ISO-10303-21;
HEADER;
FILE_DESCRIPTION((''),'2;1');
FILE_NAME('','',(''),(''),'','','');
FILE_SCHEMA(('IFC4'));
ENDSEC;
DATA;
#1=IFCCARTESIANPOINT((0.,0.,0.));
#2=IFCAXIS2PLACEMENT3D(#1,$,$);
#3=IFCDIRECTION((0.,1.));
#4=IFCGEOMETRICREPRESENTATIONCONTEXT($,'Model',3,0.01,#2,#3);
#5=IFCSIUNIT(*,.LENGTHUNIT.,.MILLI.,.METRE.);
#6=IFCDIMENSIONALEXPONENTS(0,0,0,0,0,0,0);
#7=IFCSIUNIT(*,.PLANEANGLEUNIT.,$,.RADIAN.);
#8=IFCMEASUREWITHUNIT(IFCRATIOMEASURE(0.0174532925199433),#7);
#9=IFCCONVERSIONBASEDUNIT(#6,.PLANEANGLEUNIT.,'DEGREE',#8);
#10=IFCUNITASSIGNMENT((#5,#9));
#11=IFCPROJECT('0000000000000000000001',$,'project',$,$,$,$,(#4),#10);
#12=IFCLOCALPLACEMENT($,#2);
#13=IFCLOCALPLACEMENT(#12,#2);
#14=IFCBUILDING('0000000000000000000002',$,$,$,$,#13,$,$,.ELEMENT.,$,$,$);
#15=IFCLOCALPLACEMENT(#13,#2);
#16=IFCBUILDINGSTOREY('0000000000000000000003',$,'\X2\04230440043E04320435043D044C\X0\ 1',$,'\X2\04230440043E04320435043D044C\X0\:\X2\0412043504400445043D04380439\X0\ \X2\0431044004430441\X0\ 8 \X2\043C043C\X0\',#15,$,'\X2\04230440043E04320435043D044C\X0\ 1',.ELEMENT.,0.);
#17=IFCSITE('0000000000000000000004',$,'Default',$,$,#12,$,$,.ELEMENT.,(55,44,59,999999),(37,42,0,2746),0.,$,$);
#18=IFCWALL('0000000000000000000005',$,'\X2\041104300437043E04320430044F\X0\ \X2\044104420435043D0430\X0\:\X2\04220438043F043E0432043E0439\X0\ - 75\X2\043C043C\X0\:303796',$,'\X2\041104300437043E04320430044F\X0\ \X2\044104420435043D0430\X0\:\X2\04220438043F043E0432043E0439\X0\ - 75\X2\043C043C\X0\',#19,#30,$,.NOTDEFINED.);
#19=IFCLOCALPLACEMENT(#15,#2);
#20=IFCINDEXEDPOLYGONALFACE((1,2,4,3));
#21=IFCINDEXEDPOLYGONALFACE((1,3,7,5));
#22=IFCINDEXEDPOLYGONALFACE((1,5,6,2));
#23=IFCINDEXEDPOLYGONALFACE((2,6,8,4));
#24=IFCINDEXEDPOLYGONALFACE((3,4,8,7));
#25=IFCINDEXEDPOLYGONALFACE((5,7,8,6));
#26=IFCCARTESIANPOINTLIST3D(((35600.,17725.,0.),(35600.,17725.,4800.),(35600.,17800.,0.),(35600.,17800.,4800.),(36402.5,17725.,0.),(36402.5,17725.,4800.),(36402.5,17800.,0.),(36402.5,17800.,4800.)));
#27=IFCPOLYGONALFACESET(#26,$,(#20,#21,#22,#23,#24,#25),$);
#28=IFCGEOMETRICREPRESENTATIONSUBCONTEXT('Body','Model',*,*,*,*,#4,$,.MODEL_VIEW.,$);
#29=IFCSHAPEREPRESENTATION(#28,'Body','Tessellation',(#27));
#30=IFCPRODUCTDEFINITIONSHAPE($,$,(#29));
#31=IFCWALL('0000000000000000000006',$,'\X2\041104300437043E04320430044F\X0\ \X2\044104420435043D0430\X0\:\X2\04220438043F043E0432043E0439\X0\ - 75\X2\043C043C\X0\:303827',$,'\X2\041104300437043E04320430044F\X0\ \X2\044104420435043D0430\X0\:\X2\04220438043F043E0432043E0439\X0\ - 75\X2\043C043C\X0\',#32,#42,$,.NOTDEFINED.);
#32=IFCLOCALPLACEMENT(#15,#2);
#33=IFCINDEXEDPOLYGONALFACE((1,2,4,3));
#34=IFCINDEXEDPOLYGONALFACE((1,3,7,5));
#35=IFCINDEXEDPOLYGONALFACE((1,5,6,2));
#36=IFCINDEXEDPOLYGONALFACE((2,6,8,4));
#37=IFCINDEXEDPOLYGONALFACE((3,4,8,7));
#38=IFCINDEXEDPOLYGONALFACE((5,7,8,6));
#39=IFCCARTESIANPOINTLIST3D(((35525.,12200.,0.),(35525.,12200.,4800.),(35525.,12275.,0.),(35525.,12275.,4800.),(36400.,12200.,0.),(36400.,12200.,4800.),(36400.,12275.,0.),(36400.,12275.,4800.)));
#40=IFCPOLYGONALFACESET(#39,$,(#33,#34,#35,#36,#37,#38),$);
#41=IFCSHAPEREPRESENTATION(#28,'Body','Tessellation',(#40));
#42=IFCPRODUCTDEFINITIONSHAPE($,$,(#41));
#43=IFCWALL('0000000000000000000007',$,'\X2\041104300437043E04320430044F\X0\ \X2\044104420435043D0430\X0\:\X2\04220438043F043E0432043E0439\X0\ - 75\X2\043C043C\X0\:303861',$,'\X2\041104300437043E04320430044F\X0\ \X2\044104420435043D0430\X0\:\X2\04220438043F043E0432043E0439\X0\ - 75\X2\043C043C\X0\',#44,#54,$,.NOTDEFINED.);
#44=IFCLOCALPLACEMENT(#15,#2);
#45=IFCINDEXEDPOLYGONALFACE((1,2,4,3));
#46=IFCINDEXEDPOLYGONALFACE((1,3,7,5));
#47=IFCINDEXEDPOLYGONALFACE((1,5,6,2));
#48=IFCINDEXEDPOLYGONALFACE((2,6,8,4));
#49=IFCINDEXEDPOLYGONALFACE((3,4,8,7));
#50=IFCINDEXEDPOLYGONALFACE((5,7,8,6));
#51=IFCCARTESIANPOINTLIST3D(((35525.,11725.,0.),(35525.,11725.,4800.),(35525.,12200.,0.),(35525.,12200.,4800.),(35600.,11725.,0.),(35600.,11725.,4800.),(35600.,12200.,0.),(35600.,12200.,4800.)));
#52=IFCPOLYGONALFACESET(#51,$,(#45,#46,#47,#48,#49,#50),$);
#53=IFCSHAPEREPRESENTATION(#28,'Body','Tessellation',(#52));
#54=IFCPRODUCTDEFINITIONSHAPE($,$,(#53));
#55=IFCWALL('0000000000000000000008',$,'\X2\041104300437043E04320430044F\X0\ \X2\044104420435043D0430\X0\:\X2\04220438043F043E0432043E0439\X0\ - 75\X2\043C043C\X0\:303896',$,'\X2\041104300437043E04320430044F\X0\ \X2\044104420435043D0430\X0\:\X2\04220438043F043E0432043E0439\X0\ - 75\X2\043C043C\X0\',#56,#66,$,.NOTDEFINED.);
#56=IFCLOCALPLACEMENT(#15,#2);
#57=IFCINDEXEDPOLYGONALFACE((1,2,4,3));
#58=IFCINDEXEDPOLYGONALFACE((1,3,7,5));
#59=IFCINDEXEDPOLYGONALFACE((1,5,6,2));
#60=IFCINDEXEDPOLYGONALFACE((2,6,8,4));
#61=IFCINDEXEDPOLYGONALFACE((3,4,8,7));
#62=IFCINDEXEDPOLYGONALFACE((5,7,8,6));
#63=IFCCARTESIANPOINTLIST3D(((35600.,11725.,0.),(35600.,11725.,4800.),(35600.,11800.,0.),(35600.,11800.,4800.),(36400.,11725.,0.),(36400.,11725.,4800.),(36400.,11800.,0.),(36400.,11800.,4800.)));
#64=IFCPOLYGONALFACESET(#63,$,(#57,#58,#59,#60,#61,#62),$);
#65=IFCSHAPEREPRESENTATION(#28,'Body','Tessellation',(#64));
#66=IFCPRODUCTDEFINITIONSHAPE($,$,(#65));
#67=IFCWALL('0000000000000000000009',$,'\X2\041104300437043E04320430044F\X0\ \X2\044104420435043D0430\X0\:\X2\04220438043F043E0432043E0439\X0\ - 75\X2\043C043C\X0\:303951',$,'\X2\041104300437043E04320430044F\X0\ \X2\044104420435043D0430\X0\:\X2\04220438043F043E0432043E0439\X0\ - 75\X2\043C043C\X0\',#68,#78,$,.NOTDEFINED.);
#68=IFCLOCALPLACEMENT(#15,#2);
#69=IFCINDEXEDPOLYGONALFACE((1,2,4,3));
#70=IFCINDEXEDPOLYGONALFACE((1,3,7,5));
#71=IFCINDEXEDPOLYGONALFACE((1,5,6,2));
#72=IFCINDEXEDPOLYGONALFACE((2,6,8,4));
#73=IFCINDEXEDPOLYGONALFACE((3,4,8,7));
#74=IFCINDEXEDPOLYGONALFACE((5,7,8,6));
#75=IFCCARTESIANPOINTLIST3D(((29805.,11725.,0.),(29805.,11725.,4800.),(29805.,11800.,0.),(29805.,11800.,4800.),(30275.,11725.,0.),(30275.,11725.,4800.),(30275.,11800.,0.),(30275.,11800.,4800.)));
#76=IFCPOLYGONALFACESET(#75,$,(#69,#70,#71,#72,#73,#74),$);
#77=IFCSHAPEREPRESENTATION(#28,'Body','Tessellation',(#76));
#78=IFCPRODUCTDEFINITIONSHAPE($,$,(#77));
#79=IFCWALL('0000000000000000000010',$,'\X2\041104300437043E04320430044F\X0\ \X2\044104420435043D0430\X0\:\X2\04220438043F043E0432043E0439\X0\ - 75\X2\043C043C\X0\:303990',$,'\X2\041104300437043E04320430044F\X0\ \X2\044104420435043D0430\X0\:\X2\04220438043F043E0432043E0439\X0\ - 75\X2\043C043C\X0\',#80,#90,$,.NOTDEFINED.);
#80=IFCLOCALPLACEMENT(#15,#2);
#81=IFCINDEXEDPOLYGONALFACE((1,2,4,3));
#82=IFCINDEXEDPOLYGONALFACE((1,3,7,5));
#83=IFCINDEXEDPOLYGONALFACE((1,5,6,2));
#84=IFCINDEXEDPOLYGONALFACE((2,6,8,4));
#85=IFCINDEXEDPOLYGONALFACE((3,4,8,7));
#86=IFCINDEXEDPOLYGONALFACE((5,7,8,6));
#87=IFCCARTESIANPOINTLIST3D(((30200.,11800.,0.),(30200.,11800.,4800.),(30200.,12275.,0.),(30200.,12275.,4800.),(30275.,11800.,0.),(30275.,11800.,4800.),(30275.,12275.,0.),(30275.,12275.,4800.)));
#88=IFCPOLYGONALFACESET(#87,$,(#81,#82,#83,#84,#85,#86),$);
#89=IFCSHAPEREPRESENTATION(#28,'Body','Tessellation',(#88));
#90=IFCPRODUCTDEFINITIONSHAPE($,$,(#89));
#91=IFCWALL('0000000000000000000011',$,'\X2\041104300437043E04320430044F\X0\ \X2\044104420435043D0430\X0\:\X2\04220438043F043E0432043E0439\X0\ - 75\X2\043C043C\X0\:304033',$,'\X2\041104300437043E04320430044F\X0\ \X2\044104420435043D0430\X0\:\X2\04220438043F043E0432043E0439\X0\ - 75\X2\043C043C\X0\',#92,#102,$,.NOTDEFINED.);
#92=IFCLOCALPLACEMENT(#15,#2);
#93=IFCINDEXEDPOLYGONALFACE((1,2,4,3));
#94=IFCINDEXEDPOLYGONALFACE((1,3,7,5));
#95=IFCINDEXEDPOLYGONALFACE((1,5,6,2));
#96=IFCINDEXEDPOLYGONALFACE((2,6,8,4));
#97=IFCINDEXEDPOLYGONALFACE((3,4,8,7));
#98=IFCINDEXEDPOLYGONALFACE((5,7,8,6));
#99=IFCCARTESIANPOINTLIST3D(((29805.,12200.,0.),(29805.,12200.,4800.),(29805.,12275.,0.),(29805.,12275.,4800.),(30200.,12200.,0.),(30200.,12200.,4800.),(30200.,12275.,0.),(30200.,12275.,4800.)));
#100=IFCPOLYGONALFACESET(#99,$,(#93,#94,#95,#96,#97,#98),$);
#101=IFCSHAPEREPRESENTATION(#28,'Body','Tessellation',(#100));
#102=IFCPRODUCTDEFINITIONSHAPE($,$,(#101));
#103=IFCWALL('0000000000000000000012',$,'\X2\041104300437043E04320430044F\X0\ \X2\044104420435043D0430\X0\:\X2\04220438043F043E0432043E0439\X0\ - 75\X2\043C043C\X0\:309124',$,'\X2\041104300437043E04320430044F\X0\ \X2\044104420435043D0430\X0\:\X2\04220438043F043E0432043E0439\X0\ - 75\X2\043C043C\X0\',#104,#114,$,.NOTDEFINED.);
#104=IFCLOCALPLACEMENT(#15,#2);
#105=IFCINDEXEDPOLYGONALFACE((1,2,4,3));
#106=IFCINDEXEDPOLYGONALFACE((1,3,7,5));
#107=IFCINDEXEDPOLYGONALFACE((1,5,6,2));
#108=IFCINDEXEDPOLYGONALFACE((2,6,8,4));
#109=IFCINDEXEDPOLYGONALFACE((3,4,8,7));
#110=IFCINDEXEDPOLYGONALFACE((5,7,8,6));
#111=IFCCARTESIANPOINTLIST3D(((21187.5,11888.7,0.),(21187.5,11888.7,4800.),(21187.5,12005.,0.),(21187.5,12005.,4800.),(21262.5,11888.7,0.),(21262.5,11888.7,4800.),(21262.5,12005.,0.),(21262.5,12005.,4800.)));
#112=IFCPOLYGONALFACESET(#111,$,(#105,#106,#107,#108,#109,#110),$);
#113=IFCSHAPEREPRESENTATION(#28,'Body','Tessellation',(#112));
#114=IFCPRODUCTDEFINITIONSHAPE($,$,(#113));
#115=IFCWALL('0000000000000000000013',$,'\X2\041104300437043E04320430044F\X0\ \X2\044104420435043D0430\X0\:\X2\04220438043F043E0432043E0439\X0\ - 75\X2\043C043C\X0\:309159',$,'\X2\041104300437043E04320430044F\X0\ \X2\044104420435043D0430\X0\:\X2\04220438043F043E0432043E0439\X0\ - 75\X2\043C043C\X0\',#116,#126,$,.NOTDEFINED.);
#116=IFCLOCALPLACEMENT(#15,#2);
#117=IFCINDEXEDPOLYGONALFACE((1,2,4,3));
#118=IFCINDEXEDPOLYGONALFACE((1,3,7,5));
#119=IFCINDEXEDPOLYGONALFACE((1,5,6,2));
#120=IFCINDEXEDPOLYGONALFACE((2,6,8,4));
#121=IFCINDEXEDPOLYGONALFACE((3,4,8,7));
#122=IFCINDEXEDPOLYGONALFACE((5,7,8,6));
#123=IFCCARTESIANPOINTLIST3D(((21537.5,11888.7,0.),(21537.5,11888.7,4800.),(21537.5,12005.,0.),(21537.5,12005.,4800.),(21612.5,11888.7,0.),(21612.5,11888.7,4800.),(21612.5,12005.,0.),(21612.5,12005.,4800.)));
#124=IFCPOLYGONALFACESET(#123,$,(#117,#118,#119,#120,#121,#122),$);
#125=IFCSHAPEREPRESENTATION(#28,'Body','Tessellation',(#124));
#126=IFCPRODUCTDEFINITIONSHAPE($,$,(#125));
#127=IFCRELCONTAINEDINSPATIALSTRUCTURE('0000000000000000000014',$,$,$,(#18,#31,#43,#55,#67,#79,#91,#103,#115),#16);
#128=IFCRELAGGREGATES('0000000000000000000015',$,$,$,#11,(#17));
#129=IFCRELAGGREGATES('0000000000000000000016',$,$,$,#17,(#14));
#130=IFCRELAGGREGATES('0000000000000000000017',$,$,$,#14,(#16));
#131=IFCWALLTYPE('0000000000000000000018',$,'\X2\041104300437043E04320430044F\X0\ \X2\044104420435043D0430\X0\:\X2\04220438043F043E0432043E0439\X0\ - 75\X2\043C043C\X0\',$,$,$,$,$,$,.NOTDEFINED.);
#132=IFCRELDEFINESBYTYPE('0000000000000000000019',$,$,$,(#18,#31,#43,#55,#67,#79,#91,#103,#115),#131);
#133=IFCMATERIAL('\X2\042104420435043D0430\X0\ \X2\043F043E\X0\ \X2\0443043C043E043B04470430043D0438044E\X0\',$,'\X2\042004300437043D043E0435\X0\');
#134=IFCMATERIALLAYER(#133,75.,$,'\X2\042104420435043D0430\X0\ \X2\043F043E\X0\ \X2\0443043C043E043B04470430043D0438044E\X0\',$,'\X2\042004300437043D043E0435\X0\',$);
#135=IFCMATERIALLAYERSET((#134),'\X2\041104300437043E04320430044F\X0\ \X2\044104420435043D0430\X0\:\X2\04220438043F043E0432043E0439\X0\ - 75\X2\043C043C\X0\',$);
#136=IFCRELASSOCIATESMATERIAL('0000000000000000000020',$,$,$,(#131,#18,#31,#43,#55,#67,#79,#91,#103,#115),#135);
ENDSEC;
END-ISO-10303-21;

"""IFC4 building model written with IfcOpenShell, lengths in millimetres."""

from ifc_helpers import new_model, entity, si_unit, converted_unit, direction, frame, frame_2d, origin, place, context, subcontext, project, spatial, rectangle, extrude, material, layer, layer_set, layer_usage, type_object, element, save


model = new_model("IFC4")

# Units and contexts
model_context = context("Model", 3, precision=0.01, world=origin(), true_north=direction((0.0, 1.0)))
body_context = subcontext(model_context, "Body", "Model", "MODEL_VIEW")
ifc_project = project(units=[si_unit("LENGTHUNIT", "METRE", prefix="MILLI"), converted_unit("PLANEANGLEUNIT", "DEGREE", entity("IfcRatioMeasure", 0.0174532925199433), si_unit("PLANEANGLEUNIT", "RADIAN"), dimensions=[0, 0, 0, 0, 0, 0, 0])], contexts=[model_context])

# Site, building, storey
site_placement = place(None, origin())
site = spatial("IfcSite", under=ifc_project, at=site_placement, Name="Default", CompositionType="ELEMENT", RefLatitude=(55, 44, 59, 999999), RefLongitude=(37, 42, 0, 2746), RefElevation=0.0)
building_placement = place(site_placement, origin())
building = spatial("IfcBuilding", under=site, at=building_placement, CompositionType="ELEMENT")
storey_placement = place(building_placement, origin())
storey = spatial("IfcBuildingStorey", under=building, at=storey_placement, Name="Уровень 1", ObjectType="Уровень:Верхний брус 8 мм", LongName="Уровень 1", CompositionType="ELEMENT", Elevation=0.0)

# Shared definitions
ifc_material = material(Name="Стена по умолчанию", Category="Разное")

# Walls
ifc_layer_1 = layer(ifc_material, 75.0, Name="Стена по умолчанию", Category="Разное")
ifc_layer_set_1 = layer_set([ifc_layer_1], Name="Базовая стена:Типовой - 75мм")
wall_type_1 = type_object("IfcWallType", Name="Базовая стена:Типовой - 75мм", PredefinedType="NOTDEFINED", material=ifc_layer_set_1)
ifc_layer_usage_1 = layer_usage(ifc_layer_set_1, "AXIS2", "NEGATIVE", 37.5)
wall_1_placement = place(storey_placement, frame((35600.0, 17762.5, 0.0)))
element("IfcWall", 1, at=wall_1_placement, inside=storey, type_object=wall_type_1, material=ifc_layer_usage_1, Name="Базовая стена:Типовой - 75мм:303796", ObjectType="Базовая стена:Типовой - 75мм", PredefinedType="NOTDEFINED", context=body_context, shape_type="SweptSolid", body=[
    extrude(rectangle(XDim=802.5, YDim=75.0, at=frame_2d((401.2, 0.0), x_axis=(-1.0, 0.0))), origin(), (0.0, 0.0, 1.0), 4800.0),
])
ifc_layer_usage_2 = layer_usage(ifc_layer_set_1, "AXIS2", "NEGATIVE", 37.5)
wall_2_placement = place(storey_placement, frame((35525.0, 12237.5, 0.0)))
element("IfcWall", 2, at=wall_2_placement, inside=storey, type_object=wall_type_1, material=ifc_layer_usage_2, Name="Базовая стена:Типовой - 75мм:303827", ObjectType="Базовая стена:Типовой - 75мм", PredefinedType="NOTDEFINED", context=body_context, shape_type="SweptSolid", body=[
    extrude(rectangle(XDim=875.0, YDim=75.0, at=frame_2d((437.5, 0.0), x_axis=(-1.0, 0.0))), origin(), (0.0, 0.0, 1.0), 4800.0),
])
ifc_layer_usage_3 = layer_usage(ifc_layer_set_1, "AXIS2", "NEGATIVE", 37.5)
wall_3_placement = place(storey_placement, frame((35562.5, 12200.0, 0.0), z_axis=(0.0, 0.0, 1.0), x_axis=(0.0, -1.0, 0.0)))
element("IfcWall", 3, at=wall_3_placement, inside=storey, type_object=wall_type_1, material=ifc_layer_usage_3, Name="Базовая стена:Типовой - 75мм:303861", ObjectType="Базовая стена:Типовой - 75мм", PredefinedType="NOTDEFINED", context=body_context, shape_type="SweptSolid", body=[
    extrude(rectangle(XDim=475.0, YDim=75.0, at=frame_2d((237.5, 0.0), x_axis=(-1.0, 0.0))), origin(), (0.0, 0.0, 1.0), 4800.0),
])
ifc_layer_usage_4 = layer_usage(ifc_layer_set_1, "AXIS2", "NEGATIVE", 37.5)
wall_4_placement = place(storey_placement, frame((35600.0, 11762.5, 0.0)))
element("IfcWall", 4, at=wall_4_placement, inside=storey, type_object=wall_type_1, material=ifc_layer_usage_4, Name="Базовая стена:Типовой - 75мм:303896", ObjectType="Базовая стена:Типовой - 75мм", PredefinedType="NOTDEFINED", context=body_context, shape_type="SweptSolid", body=[
    extrude(rectangle(XDim=800.0, YDim=75.0, at=frame_2d((400.0, 0.0), x_axis=(-1.0, 0.0))), origin(), (0.0, 0.0, 1.0), 4800.0),
])
ifc_layer_usage_5 = layer_usage(ifc_layer_set_1, "AXIS2", "NEGATIVE", 37.5)
wall_5_placement = place(storey_placement, frame((29805.0, 11762.5, 0.0)))
element("IfcWall", 5, at=wall_5_placement, inside=storey, type_object=wall_type_1, material=ifc_layer_usage_5, Name="Базовая стена:Типовой - 75мм:303951", ObjectType="Базовая стена:Типовой - 75мм", PredefinedType="NOTDEFINED", context=body_context, shape_type="SweptSolid", body=[
    extrude(rectangle(XDim=470.0, YDim=75.0, at=frame_2d((235.0, 0.0), x_axis=(-1.0, 0.0))), origin(), (0.0, 0.0, 1.0), 4800.0),
])
ifc_layer_usage_6 = layer_usage(ifc_layer_set_1, "AXIS2", "NEGATIVE", 37.5)
wall_6_placement = place(storey_placement, frame((30237.5, 11800.0, 0.0), z_axis=(0.0, 0.0, 1.0), x_axis=(0.0, 1.0, 0.0)))
element("IfcWall", 6, at=wall_6_placement, inside=storey, type_object=wall_type_1, material=ifc_layer_usage_6, Name="Базовая стена:Типовой - 75мм:303990", ObjectType="Базовая стена:Типовой - 75мм", PredefinedType="NOTDEFINED", context=body_context, shape_type="SweptSolid", body=[
    extrude(rectangle(XDim=475.0, YDim=75.0, at=frame_2d((237.5, 0.0), x_axis=(-1.0, 0.0))), origin(), (0.0, 0.0, 1.0), 4800.0),
])
ifc_layer_usage_7 = layer_usage(ifc_layer_set_1, "AXIS2", "NEGATIVE", 37.5)
wall_7_placement = place(storey_placement, frame((30200.0, 12237.5, 0.0), z_axis=(0.0, 0.0, 1.0), x_axis=(-1.0, 0.0, 0.0)))
element("IfcWall", 7, at=wall_7_placement, inside=storey, type_object=wall_type_1, material=ifc_layer_usage_7, Name="Базовая стена:Типовой - 75мм:304033", ObjectType="Базовая стена:Типовой - 75мм", PredefinedType="NOTDEFINED", context=body_context, shape_type="SweptSolid", body=[
    extrude(rectangle(XDim=395.0, YDim=75.0, at=frame_2d((197.5, 0.0), x_axis=(-1.0, 0.0))), origin(), (0.0, 0.0, 1.0), 4800.0),
])
ifc_layer_usage_8 = layer_usage(ifc_layer_set_1, "AXIS2", "NEGATIVE", 37.5)
wall_8_placement = place(storey_placement, frame((21225.0, 11888.7, 0.0), z_axis=(0.0, 0.0, 1.0), x_axis=(0.0, 1.0, 0.0)))
element("IfcWall", 8, at=wall_8_placement, inside=storey, type_object=wall_type_1, material=ifc_layer_usage_8, Name="Базовая стена:Типовой - 75мм:309124", ObjectType="Базовая стена:Типовой - 75мм", PredefinedType="NOTDEFINED", context=body_context, shape_type="SweptSolid", body=[
    extrude(rectangle(XDim=116.3, YDim=75.0, at=frame_2d((58.1, 0.0), x_axis=(-1.0, 0.0))), origin(), (0.0, 0.0, 1.0), 4800.0),
])
ifc_layer_usage_9 = layer_usage(ifc_layer_set_1, "AXIS2", "NEGATIVE", 37.5)
wall_9_placement = place(storey_placement, frame((21575.0, 11888.7, 0.0), z_axis=(0.0, 0.0, 1.0), x_axis=(0.0, 1.0, 0.0)))
element("IfcWall", 9, at=wall_9_placement, inside=storey, type_object=wall_type_1, material=ifc_layer_usage_9, Name="Базовая стена:Типовой - 75мм:309159", ObjectType="Базовая стена:Типовой - 75мм", PredefinedType="NOTDEFINED", context=body_context, shape_type="SweptSolid", body=[
    extrude(rectangle(XDim=116.3, YDim=75.0, at=frame_2d((58.1, 0.0), x_axis=(-1.0, 0.0))), origin(), (0.0, 0.0, 1.0), 4800.0),
])

save(model, "model.ifc")
